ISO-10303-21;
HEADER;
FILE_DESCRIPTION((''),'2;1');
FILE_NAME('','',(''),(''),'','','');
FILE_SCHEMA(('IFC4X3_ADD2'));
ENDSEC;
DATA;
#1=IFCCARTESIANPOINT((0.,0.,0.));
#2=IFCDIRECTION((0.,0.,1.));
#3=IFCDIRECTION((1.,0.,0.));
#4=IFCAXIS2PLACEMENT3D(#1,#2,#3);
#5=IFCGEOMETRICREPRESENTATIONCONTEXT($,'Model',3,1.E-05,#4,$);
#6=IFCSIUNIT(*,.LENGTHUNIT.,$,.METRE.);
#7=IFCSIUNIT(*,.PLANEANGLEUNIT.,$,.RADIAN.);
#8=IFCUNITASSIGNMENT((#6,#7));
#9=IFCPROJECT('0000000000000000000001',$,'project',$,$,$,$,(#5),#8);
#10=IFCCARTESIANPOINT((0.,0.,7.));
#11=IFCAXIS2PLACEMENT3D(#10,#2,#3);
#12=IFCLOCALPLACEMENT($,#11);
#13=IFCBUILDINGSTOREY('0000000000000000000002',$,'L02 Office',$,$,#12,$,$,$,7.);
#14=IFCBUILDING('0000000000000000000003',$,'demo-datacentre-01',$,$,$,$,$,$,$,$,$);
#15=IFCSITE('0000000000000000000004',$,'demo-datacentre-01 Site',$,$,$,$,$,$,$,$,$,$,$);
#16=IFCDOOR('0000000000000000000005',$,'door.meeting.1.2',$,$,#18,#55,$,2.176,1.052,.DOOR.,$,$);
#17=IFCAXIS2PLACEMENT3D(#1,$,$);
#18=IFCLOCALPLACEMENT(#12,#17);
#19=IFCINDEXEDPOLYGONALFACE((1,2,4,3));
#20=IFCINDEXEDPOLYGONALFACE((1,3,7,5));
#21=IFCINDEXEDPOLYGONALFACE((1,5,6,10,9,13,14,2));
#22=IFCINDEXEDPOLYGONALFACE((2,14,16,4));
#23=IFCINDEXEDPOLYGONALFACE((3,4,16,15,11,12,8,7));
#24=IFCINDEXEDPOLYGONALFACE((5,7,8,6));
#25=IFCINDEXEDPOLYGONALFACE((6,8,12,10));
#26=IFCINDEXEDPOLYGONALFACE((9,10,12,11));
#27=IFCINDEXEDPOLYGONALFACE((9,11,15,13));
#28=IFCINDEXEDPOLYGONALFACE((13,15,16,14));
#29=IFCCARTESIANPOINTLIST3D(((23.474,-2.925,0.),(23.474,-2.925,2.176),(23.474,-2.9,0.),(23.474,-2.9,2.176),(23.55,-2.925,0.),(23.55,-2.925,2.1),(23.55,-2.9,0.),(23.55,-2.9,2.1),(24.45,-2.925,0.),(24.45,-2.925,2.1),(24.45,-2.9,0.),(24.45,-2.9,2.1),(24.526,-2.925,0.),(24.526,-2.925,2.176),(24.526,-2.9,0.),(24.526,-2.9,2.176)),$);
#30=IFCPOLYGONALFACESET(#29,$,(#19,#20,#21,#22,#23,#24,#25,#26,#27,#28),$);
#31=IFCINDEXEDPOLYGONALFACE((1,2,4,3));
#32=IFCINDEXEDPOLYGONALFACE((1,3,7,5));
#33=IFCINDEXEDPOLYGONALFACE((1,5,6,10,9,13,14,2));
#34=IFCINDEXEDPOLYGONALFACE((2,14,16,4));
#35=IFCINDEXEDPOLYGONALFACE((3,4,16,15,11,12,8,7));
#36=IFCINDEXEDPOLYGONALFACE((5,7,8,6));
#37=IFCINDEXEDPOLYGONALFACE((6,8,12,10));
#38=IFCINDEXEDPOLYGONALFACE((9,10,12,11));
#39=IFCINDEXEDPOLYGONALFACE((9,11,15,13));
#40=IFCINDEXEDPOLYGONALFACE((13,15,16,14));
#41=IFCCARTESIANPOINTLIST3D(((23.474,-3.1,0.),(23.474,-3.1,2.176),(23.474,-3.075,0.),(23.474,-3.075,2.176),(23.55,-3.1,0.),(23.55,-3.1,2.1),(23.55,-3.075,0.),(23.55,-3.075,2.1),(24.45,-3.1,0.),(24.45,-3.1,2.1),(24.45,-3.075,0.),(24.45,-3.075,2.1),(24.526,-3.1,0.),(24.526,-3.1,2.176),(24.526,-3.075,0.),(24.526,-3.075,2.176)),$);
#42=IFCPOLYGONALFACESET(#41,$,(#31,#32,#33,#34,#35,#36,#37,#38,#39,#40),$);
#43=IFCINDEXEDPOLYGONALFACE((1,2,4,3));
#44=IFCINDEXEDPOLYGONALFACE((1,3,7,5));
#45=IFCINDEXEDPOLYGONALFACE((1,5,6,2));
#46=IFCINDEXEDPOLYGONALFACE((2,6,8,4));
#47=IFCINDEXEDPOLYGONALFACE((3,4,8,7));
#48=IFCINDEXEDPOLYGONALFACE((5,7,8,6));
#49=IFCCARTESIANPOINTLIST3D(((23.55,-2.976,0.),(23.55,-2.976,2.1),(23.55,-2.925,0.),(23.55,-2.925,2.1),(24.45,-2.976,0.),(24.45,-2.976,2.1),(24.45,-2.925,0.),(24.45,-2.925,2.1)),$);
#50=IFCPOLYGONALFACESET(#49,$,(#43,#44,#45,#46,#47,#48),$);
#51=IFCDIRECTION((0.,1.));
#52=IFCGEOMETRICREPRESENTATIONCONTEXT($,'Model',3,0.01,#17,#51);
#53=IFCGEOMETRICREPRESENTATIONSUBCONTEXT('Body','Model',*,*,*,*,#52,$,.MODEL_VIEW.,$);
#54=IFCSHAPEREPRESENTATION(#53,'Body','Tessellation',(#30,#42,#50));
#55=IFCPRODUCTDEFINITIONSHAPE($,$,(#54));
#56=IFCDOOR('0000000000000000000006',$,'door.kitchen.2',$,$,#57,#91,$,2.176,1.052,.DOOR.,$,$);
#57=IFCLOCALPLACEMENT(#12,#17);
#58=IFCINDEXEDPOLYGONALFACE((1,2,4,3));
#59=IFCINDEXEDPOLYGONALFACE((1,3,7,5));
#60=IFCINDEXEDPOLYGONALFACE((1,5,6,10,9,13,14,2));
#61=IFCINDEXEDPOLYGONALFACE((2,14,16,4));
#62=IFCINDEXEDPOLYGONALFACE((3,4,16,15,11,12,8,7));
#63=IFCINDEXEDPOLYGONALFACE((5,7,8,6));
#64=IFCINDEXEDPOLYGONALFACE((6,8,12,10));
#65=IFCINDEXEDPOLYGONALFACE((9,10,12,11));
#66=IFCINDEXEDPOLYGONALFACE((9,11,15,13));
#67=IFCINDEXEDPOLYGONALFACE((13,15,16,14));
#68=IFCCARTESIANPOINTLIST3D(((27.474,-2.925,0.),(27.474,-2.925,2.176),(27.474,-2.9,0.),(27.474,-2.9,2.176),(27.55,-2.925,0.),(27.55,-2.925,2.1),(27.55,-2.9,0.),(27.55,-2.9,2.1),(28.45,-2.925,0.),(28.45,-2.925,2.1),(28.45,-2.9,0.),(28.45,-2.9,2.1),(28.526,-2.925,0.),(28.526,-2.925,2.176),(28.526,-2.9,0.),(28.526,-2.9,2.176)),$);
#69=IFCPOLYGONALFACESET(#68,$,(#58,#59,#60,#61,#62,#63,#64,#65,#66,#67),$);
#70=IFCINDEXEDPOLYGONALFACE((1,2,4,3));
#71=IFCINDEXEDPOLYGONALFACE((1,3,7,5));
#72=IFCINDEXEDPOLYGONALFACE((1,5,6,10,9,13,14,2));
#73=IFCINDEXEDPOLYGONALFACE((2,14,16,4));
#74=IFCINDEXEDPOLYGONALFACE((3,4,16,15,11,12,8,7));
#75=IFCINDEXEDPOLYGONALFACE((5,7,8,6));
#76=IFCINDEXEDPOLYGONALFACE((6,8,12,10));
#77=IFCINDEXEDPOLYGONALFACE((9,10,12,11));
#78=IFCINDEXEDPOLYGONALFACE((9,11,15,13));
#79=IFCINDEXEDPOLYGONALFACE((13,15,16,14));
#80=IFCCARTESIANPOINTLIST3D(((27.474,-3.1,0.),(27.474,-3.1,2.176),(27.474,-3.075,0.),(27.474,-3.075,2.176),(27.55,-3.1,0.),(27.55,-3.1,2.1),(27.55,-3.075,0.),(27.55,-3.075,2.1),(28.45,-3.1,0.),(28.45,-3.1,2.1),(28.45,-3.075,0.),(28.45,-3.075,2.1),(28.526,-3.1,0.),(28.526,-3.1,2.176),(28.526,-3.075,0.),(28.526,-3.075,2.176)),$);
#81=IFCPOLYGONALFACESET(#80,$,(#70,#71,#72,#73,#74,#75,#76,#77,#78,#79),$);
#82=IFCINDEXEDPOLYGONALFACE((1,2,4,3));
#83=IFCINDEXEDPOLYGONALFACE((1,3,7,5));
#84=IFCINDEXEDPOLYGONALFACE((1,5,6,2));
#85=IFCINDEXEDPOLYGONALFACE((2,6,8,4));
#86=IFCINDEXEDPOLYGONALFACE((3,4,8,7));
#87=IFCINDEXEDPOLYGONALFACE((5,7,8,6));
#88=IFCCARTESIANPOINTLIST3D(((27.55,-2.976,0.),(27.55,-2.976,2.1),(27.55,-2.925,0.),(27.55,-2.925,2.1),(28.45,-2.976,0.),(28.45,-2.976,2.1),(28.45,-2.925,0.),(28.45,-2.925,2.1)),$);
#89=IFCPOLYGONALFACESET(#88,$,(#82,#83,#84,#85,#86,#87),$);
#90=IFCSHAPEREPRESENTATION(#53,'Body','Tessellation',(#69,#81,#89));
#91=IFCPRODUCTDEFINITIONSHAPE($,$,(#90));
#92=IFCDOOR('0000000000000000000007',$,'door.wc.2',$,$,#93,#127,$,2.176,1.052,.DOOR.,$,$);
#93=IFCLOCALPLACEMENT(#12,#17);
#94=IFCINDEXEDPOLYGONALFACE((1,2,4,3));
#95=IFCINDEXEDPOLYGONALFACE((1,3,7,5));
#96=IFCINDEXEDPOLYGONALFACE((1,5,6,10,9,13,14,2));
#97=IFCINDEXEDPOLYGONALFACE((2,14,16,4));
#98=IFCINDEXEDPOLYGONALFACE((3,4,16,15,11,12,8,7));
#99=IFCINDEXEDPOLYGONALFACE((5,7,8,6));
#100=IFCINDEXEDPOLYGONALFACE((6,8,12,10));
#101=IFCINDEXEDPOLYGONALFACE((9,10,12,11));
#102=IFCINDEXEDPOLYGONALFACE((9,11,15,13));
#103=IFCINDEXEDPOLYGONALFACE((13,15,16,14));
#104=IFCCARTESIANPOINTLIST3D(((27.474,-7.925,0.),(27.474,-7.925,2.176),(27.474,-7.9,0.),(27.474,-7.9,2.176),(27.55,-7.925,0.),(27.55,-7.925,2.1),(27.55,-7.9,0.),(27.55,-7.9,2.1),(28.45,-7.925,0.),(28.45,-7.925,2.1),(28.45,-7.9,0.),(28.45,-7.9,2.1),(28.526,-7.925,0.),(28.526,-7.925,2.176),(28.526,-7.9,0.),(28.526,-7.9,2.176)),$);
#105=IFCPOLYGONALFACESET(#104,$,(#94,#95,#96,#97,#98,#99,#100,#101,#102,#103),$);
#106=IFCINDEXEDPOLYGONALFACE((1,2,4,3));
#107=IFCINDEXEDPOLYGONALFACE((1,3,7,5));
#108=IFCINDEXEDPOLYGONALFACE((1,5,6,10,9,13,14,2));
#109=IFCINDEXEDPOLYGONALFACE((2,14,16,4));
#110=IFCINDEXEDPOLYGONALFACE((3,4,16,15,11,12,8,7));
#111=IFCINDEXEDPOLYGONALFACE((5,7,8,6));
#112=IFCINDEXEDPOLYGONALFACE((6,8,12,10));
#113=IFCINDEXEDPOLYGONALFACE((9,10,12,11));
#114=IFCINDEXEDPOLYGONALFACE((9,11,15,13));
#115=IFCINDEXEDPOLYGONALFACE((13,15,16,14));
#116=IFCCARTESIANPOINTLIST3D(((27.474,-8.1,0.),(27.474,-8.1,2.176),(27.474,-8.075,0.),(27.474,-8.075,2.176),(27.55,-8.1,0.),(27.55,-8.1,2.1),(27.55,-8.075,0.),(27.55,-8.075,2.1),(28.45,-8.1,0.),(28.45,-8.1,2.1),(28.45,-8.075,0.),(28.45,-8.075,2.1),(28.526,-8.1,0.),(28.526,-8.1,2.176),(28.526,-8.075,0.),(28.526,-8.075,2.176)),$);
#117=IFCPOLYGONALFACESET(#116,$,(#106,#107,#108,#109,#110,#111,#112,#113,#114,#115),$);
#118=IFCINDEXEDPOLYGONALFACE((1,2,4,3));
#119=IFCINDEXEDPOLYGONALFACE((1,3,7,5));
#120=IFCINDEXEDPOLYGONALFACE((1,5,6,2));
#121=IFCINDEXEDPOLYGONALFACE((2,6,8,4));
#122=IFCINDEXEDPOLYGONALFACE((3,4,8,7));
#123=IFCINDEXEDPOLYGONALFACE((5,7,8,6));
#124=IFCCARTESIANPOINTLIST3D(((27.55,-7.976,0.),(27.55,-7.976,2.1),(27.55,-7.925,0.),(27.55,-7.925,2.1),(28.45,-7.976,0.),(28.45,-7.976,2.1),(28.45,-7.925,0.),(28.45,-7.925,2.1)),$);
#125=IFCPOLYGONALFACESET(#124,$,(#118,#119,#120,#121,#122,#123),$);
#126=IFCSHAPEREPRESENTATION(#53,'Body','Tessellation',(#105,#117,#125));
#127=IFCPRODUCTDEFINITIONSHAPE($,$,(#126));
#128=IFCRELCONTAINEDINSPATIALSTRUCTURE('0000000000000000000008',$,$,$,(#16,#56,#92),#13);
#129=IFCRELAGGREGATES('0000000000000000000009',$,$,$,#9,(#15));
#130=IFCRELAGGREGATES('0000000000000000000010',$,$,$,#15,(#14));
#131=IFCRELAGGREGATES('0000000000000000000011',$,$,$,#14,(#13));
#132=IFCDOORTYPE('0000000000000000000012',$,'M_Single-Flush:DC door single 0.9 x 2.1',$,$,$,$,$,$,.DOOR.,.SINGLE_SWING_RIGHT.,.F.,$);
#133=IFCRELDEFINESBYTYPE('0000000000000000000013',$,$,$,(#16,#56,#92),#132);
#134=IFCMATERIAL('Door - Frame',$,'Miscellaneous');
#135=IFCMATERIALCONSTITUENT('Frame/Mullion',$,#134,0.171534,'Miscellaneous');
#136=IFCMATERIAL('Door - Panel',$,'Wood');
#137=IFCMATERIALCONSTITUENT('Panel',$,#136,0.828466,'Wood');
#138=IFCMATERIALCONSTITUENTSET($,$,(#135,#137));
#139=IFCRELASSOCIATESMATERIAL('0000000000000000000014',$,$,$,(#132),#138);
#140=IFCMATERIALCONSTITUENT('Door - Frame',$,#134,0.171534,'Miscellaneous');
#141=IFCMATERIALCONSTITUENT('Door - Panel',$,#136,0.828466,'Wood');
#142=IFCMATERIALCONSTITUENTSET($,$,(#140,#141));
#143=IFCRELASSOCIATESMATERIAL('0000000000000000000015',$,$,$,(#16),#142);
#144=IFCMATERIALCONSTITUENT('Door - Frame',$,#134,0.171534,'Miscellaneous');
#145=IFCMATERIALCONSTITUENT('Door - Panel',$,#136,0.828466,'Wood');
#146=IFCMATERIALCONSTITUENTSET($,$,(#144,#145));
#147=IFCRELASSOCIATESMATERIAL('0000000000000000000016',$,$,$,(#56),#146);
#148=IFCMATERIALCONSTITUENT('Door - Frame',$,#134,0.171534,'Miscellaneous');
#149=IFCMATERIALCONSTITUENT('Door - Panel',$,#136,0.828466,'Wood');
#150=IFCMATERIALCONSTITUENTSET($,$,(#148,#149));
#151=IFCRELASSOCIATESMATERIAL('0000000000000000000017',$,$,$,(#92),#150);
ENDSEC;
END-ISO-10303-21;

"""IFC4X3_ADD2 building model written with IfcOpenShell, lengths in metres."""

from ifc_helpers import new_model, si_unit, direction, frame, frame_2d, origin, origin_with_axes, place, context, subcontext, project, spatial, polyline, rectangle, outline, extrude, source, transform, mapped, material, constituent, constituent_set, type_object, type_shapes, element, save


model = new_model("IFC4X3_ADD2")

# Units and contexts
model_context_1 = context("Model", 3, precision=0.01, world=origin(), true_north=direction((0.0, 1.0)))
model_context_2 = context("Model", 3, precision=1e-05, world=origin_with_axes())
body_context = subcontext(model_context_1, "Body", "Model", "MODEL_VIEW")
ifc_project = project(units=[si_unit("LENGTHUNIT", "METRE"), si_unit("PLANEANGLEUNIT", "RADIAN")], contexts=[model_context_2])

# Site, building, storey
site = spatial("IfcSite", under=ifc_project, Name="demo-datacentre-01 Site")
building = spatial("IfcBuilding", under=site, Name="demo-datacentre-01")
storey_placement = place(None, frame((0.0, 0.0, 7.0), z_axis=(0.0, 0.0, 1.0), x_axis=(1.0, 0.0, 0.0)))
storey = spatial("IfcBuildingStorey", under=building, at=storey_placement, Name="L02 Office", Elevation=7.0)

# Shared definitions
placement_1 = place(None, origin())
placement_2 = place(placement_1, origin())
placement_3 = place(placement_2, frame((0.0, 0.0, 7.0)))

# Doors
ifc_material_1 = material(Name="Door - Frame", Category="Miscellaneous")
ifc_material_2 = material(Name="Door - Panel", Category="Wood")
ifc_constituent_1 = constituent(ifc_material_1, Name="Frame/Mullion", Category="Miscellaneous", fraction=0.171534)
ifc_constituent_2 = constituent(ifc_material_2, Name="Panel", Category="Wood", fraction=0.828466)
ifc_constituent_set_1 = constituent_set(constituents=[ifc_constituent_1, ifc_constituent_2])
door_type_1 = type_object("IfcDoorType", Name="M_Single-Flush:DC door single 0.9 x 2.1", OperationType="SINGLE_SWING_RIGHT", ParameterTakesPrecedence=False, PredefinedType="DOOR", material=ifc_constituent_set_1)
shared_shape_1 = source(origin(), body_context, "Body", "SweptSolid", [
    extrude(outline(polyline([(-0.526, -1.107), (0.526, -1.107), (0.526, 1.069), (0.45, 1.069), (0.45, -1.031), (-0.45, -1.031), (-0.45, 1.069), (-0.526, 1.069), (-0.526, -1.107)])), frame((0.45, 0.15, 1.069), z_axis=(0.0, 1.0, 0.0), x_axis=(1.0, 0.0, 0.0)), (0.0, 0.0, 1.0), 0.025),
    extrude(outline(polyline([(-1.107, -0.526), (1.069, -0.526), (1.069, -0.45), (-1.031, -0.45), (-1.031, 0.45), (1.069, 0.45), (1.069, 0.526), (-1.107, 0.526), (-1.107, -0.526)])), frame((0.45, -0.025, 1.069), z_axis=(0.0, 1.0, 0.0), x_axis=(0.0, 0.0, -1.0)), (0.0, 0.0, 1.0), 0.025),
    extrude(rectangle(XDim=0.051, YDim=0.9, at=frame_2d((0.0, 0.0), x_axis=(1.0, 0.0))), frame((0.45, 0.1245, 0.0), z_axis=(0.0, 0.0, 1.0), x_axis=(0.0, 1.0, 0.0)), (0.0, 0.0, 1.0), 2.1),
])
type_shapes(door_type_1, [shared_shape_1])
ifc_constituent_3 = constituent(ifc_material_1, Name="Door - Frame", Category="Miscellaneous", fraction=0.171534)
ifc_constituent_4 = constituent(ifc_material_2, Name="Door - Panel", Category="Wood", fraction=0.828466)
ifc_constituent_set_2 = constituent_set(constituents=[ifc_constituent_3, ifc_constituent_4])
door_1_placement = place(placement_3, frame((23.55, -3.075, 0.0)))
element("IfcDoor", 1, at=door_1_placement, inside=storey, type_object=door_type_1, material=ifc_constituent_set_2, Name="door.meeting.1.2", OverallHeight=2.176, OverallWidth=1.052, PredefinedType="DOOR", context=body_context, shape_type="MappedRepresentation", body=[
    mapped(shared_shape_1, transform((0.0, 0.0, 0.0), scale=1.0)),
])
ifc_constituent_5 = constituent(ifc_material_1, Name="Door - Frame", Category="Miscellaneous", fraction=0.171534)
ifc_constituent_6 = constituent(ifc_material_2, Name="Door - Panel", Category="Wood", fraction=0.828466)
ifc_constituent_set_3 = constituent_set(constituents=[ifc_constituent_5, ifc_constituent_6])
door_2_placement = place(placement_3, frame((27.55, -3.075, 0.0)))
element("IfcDoor", 2, at=door_2_placement, inside=storey, type_object=door_type_1, material=ifc_constituent_set_3, Name="door.kitchen.2", OverallHeight=2.176, OverallWidth=1.052, PredefinedType="DOOR", context=body_context, shape_type="MappedRepresentation", body=[
    mapped(shared_shape_1, transform((0.0, 0.0, 0.0), scale=1.0)),
])
ifc_constituent_7 = constituent(ifc_material_1, Name="Door - Frame", Category="Miscellaneous", fraction=0.171534)
ifc_constituent_8 = constituent(ifc_material_2, Name="Door - Panel", Category="Wood", fraction=0.828466)
ifc_constituent_set_4 = constituent_set(constituents=[ifc_constituent_7, ifc_constituent_8])
door_3_placement = place(placement_3, frame((27.55, -8.075, 0.0)))
element("IfcDoor", 3, at=door_3_placement, inside=storey, type_object=door_type_1, material=ifc_constituent_set_4, Name="door.wc.2", OverallHeight=2.176, OverallWidth=1.052, PredefinedType="DOOR", context=body_context, shape_type="MappedRepresentation", body=[
    mapped(shared_shape_1, transform((0.0, 0.0, 0.0), scale=1.0)),
])

save(model, "model.ifc")
